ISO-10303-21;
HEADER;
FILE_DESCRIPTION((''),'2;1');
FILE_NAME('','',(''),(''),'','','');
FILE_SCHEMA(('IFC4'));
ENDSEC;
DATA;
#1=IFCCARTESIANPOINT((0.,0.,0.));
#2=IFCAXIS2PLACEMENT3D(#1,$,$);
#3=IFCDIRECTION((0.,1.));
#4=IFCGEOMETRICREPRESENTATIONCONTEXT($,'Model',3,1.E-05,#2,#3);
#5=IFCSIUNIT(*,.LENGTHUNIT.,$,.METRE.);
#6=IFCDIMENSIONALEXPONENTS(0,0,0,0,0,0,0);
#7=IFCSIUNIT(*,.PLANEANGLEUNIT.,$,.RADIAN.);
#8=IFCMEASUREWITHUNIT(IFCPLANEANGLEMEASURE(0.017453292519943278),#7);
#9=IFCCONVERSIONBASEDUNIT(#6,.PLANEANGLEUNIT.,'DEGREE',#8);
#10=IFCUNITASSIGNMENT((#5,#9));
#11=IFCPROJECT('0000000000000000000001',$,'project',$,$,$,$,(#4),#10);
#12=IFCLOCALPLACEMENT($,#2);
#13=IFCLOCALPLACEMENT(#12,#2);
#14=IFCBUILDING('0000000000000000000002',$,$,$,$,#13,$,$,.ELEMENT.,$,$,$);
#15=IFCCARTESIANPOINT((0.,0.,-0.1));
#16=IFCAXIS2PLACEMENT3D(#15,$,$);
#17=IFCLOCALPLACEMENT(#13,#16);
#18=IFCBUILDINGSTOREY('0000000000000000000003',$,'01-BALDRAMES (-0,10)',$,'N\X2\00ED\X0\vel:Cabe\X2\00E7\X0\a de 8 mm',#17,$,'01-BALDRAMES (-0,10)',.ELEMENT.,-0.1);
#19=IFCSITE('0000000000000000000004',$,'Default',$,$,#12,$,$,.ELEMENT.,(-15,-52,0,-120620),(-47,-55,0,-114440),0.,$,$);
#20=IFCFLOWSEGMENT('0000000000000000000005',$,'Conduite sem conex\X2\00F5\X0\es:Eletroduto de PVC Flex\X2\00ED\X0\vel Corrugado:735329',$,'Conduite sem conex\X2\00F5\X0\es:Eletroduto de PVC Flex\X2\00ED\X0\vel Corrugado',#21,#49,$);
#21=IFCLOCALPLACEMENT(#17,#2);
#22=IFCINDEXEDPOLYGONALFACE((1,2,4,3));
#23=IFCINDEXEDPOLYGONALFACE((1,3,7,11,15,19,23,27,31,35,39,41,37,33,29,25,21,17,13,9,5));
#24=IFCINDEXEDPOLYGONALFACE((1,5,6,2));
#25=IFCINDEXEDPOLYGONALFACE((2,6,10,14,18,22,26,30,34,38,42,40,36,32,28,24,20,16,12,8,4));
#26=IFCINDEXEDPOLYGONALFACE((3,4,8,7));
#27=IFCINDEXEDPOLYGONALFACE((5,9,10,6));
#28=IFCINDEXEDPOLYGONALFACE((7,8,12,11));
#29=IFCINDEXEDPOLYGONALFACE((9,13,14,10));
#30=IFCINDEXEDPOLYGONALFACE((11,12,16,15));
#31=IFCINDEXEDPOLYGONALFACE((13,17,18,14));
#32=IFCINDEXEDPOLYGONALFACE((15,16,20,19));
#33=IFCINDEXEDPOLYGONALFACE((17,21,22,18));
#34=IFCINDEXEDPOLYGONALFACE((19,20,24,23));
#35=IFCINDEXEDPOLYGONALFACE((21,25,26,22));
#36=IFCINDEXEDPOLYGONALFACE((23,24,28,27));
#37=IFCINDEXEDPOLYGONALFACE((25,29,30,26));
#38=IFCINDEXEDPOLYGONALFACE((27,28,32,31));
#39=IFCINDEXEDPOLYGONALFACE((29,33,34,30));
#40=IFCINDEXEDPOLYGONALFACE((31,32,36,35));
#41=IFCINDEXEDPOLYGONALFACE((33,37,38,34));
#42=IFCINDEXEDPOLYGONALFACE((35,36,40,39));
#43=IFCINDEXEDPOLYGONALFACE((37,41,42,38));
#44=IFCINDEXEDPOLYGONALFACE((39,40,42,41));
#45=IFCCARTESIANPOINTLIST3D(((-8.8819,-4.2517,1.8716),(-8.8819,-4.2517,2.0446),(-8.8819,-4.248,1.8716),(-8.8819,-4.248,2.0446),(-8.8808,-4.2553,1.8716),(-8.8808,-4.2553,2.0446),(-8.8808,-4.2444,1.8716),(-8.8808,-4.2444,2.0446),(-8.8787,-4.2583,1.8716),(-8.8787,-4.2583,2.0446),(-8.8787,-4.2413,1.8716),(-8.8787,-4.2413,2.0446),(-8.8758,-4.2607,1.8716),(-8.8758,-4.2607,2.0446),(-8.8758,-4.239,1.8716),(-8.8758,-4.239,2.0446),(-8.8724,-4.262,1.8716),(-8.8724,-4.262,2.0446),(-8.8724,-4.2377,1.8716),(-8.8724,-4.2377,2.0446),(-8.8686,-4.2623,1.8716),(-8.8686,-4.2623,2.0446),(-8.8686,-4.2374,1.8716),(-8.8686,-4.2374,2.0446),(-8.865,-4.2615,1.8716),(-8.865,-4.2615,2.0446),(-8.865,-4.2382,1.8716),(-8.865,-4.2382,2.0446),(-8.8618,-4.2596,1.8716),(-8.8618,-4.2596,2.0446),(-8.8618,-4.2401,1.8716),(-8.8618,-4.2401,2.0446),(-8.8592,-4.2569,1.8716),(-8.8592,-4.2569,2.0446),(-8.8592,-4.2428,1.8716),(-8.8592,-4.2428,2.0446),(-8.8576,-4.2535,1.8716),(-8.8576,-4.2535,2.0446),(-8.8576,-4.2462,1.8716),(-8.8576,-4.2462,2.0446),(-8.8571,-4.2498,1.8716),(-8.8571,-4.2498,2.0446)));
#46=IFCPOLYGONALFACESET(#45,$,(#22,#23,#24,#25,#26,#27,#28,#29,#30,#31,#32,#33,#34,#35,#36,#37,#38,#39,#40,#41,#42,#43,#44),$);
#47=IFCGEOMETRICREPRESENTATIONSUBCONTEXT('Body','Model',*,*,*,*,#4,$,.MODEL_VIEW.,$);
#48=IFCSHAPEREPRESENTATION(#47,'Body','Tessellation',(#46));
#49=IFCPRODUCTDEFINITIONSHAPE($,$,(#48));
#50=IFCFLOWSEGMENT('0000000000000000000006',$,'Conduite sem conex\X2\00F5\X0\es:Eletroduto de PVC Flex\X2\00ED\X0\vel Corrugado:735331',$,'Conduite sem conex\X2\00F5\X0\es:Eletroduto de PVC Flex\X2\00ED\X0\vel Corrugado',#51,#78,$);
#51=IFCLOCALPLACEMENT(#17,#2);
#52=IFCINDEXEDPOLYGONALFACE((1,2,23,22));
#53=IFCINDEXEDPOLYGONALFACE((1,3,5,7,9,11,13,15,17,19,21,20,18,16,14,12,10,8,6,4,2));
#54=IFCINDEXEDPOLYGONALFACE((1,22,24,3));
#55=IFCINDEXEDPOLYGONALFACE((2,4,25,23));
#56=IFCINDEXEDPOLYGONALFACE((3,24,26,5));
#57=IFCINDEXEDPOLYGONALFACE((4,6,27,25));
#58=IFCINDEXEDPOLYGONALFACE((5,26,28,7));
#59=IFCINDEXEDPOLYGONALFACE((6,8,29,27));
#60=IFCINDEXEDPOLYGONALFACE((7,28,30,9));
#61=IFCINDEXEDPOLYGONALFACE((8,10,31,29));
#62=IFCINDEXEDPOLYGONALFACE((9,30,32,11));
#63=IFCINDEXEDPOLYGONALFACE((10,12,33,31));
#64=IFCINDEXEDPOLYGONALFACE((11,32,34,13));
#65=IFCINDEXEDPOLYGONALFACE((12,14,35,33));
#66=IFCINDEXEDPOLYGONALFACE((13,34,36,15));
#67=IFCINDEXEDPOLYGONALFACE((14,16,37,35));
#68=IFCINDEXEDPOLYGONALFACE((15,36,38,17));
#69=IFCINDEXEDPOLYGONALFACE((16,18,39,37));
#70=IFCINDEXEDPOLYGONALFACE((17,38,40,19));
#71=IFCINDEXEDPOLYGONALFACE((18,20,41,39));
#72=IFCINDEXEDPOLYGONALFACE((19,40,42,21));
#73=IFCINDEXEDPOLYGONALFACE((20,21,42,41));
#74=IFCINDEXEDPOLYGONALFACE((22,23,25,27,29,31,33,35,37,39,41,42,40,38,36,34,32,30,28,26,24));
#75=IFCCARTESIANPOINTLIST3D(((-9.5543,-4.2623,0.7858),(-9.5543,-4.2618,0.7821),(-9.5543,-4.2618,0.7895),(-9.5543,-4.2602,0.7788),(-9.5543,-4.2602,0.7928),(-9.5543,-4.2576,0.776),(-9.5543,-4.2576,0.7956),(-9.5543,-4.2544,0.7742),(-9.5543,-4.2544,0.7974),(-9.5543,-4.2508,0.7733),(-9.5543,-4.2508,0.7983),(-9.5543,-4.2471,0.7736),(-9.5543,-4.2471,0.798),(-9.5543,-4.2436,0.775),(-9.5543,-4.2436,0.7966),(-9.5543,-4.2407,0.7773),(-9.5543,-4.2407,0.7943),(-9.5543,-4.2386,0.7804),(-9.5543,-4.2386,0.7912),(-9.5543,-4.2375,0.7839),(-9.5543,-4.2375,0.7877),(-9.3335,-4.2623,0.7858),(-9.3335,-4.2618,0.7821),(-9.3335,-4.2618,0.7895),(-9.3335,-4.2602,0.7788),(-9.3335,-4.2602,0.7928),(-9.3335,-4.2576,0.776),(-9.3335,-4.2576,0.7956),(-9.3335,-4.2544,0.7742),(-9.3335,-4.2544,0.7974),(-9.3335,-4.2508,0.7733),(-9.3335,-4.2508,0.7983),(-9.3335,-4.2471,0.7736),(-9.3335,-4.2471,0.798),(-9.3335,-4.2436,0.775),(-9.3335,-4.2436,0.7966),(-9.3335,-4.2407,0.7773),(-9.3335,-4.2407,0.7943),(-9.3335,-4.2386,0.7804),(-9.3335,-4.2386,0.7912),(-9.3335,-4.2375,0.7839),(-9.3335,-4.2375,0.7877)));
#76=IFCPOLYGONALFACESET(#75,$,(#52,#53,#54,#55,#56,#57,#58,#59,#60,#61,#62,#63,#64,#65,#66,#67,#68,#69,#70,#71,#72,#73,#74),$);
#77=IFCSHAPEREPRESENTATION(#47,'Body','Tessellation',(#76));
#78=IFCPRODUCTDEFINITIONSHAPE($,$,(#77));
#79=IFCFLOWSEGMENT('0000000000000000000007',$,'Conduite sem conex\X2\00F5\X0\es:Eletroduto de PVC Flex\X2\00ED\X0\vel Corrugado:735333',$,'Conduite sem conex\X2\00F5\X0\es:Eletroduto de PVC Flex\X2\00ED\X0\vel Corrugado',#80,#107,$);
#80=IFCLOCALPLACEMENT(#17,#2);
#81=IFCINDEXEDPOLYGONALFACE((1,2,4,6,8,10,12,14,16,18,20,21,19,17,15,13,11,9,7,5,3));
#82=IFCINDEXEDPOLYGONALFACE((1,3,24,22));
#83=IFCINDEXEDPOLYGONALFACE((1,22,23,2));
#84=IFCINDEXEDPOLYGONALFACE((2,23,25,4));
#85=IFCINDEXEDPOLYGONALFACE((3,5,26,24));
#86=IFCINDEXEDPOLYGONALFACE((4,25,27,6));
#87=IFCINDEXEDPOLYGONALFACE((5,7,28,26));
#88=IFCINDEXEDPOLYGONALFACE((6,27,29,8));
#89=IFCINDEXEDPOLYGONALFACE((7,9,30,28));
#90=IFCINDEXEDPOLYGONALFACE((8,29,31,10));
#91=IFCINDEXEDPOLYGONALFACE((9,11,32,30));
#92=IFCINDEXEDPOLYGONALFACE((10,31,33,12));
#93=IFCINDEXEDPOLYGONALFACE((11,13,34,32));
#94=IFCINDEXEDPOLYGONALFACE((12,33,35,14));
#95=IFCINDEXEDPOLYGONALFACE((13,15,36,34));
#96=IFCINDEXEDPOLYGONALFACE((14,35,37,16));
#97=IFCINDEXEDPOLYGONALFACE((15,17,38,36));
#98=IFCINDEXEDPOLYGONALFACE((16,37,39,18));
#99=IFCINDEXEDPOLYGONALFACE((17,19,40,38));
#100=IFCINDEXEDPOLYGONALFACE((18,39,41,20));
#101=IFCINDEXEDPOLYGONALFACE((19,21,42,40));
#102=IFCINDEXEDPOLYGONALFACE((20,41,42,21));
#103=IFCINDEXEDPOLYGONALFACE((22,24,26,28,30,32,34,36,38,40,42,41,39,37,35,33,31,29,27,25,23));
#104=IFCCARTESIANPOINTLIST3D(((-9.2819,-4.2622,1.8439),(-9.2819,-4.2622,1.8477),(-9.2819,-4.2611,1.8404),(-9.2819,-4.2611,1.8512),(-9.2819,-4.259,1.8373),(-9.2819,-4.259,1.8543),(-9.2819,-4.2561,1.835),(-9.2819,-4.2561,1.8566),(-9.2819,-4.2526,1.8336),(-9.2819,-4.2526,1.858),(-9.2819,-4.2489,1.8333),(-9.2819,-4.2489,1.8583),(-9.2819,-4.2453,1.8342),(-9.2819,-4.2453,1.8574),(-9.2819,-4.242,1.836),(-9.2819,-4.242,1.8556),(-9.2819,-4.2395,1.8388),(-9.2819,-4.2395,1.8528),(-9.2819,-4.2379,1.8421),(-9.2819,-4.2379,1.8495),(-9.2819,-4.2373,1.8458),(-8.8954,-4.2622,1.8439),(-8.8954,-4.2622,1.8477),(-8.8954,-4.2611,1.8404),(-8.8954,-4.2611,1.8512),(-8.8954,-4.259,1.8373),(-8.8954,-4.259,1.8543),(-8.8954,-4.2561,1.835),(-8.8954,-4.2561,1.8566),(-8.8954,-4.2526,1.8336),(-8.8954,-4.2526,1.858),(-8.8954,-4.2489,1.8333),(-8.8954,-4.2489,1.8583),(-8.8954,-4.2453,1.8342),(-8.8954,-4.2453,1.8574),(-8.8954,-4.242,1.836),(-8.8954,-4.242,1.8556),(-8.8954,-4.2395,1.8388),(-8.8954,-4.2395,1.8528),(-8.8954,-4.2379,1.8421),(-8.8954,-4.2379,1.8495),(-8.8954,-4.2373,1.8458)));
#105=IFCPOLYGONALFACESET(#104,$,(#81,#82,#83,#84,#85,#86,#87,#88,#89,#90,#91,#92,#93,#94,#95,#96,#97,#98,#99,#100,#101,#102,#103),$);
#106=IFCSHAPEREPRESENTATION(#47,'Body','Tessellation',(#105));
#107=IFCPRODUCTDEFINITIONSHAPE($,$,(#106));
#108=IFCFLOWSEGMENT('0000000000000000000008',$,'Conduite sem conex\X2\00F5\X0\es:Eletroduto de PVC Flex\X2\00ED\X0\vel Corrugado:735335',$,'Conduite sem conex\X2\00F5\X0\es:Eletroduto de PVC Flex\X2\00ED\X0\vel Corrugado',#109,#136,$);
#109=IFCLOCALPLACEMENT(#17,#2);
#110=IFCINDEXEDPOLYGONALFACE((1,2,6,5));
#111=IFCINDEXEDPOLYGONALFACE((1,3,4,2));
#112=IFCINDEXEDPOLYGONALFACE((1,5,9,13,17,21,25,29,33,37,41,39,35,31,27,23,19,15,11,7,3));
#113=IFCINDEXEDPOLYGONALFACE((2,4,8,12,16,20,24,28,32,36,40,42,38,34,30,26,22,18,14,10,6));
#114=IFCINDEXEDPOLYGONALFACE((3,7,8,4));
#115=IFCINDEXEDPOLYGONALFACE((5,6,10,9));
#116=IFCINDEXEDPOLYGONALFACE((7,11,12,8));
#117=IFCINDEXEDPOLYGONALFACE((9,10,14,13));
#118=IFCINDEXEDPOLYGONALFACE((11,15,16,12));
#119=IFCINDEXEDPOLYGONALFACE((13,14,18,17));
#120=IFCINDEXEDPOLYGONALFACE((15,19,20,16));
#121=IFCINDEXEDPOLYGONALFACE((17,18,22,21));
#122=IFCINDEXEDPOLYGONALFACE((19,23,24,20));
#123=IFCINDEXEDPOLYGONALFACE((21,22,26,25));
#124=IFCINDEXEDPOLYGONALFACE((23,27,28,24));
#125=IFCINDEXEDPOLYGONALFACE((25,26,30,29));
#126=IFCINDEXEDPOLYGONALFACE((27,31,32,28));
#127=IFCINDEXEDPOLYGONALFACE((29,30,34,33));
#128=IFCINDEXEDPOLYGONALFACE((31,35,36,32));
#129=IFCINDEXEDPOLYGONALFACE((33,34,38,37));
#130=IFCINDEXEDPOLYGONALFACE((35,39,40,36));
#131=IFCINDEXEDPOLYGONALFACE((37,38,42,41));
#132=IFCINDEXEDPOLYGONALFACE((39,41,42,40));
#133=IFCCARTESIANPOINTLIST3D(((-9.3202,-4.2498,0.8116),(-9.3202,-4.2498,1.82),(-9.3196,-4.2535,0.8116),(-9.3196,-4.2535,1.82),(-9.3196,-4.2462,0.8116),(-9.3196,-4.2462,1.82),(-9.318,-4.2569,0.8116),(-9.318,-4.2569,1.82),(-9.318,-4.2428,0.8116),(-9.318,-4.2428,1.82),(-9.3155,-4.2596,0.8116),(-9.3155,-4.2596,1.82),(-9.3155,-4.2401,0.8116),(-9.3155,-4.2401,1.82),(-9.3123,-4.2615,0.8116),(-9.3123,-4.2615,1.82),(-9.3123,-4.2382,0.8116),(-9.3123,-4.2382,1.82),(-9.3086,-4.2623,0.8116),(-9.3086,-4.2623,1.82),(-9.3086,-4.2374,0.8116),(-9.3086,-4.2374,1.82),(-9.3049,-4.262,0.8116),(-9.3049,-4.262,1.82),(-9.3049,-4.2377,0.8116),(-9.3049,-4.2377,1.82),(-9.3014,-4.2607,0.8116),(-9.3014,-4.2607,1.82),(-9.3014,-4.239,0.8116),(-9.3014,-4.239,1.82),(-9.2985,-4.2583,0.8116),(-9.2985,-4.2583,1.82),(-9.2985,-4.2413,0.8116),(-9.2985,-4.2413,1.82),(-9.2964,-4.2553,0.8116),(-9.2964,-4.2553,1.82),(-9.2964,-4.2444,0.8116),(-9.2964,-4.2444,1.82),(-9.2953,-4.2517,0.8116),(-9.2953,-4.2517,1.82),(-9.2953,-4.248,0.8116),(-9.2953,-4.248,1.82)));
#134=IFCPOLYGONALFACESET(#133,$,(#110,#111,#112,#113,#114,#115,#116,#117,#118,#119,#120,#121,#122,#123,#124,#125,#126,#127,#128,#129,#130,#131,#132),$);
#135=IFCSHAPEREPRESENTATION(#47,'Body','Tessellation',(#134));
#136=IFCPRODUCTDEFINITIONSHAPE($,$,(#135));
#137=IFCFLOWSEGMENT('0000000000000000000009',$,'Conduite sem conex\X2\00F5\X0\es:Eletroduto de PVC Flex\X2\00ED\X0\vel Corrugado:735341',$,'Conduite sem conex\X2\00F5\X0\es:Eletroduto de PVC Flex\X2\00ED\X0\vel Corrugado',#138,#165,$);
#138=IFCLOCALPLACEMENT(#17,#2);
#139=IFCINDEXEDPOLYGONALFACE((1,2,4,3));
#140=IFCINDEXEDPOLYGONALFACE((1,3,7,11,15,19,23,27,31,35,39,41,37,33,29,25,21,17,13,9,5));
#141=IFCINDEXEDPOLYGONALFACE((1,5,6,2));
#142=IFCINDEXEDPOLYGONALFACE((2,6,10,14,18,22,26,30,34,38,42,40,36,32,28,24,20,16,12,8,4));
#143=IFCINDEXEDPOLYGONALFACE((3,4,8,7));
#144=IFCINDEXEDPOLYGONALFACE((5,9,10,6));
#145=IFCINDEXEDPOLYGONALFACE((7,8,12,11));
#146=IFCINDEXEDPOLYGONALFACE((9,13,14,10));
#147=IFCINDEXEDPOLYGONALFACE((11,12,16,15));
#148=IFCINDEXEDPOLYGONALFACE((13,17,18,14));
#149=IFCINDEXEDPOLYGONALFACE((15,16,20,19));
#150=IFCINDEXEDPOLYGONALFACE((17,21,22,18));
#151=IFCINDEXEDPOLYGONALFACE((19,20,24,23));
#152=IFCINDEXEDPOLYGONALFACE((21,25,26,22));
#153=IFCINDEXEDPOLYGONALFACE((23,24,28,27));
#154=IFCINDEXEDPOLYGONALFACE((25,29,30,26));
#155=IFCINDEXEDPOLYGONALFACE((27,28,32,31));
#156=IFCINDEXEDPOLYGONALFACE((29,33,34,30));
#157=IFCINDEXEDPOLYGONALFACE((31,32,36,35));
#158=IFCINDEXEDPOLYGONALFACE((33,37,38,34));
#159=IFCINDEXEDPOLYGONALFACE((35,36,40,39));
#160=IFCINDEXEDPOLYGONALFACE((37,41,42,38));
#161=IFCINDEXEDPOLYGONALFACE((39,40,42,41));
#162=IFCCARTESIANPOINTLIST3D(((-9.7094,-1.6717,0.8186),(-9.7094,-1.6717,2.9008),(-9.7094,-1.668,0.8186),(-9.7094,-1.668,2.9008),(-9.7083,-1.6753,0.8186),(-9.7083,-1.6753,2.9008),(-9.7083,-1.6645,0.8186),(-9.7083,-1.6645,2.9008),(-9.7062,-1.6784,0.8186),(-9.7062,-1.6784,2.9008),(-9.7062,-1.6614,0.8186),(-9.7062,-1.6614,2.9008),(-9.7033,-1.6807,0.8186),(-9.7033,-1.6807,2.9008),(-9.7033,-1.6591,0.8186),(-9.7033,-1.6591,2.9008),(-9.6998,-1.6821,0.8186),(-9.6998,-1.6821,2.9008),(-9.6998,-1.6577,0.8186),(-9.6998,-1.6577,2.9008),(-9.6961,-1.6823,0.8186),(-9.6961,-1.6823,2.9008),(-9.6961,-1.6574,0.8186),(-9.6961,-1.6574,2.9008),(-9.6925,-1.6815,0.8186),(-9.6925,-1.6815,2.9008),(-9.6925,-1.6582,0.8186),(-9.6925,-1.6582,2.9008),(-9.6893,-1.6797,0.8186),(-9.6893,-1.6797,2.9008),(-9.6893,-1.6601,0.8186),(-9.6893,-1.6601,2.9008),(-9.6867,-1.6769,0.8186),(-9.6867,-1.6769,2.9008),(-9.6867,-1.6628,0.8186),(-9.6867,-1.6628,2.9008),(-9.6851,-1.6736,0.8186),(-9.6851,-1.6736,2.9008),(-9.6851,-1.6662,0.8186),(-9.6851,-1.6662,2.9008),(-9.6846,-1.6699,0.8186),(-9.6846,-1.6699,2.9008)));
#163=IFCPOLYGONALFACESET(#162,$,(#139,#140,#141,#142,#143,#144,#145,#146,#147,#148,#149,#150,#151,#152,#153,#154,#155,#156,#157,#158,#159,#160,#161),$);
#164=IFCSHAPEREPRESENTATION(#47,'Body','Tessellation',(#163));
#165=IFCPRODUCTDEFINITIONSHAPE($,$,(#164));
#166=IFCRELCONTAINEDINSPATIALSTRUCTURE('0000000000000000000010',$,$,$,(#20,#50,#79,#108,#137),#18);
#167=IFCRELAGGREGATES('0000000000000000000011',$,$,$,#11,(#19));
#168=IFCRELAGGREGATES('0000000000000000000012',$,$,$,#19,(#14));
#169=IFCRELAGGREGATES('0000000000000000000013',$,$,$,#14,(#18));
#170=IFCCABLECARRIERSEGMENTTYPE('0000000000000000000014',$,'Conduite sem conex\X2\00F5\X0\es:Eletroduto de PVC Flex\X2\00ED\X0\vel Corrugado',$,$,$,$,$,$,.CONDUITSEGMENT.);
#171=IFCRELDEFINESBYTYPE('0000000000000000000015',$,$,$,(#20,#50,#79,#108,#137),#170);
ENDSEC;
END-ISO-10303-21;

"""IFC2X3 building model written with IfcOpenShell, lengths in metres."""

from ifc_helpers import new_model, entity, si_unit, converted_unit, direction, frame, frame_2d, origin, origin_2d_with_axis, place, context, subcontext, project, spatial, circle, extrude, type_object, element, save


model = new_model("IFC2X3")

# Units and contexts
model_context = context("Model", 3, precision=1e-05, world=origin(), true_north=direction((0.0, 1.0)))
body_context = subcontext(model_context, "Body", "Model", "MODEL_VIEW")
ifc_project = project(units=[si_unit("LENGTHUNIT", "METRE"), converted_unit("PLANEANGLEUNIT", "DEGREE", entity("IfcPlaneAngleMeasure", 0.017453292519943278), si_unit("PLANEANGLEUNIT", "RADIAN"), dimensions=[0, 0, 0, 0, 0, 0, 0])], contexts=[model_context])

# Site, building, storey
site_placement = place(None, origin())
site = spatial("IfcSite", under=ifc_project, at=site_placement, Name="Default", CompositionType="ELEMENT", RefLatitude=(-15, -52, 0, -120620), RefLongitude=(-47, -55, 0, -114440), RefElevation=0.0)
building_placement = place(site_placement, origin())
building = spatial("IfcBuilding", under=site, at=building_placement, CompositionType="ELEMENT")
storey_placement = place(building_placement, frame((0.0, 0.0, -0.1)))
storey = spatial("IfcBuildingStorey", under=building, at=storey_placement, Name="01-BALDRAMES (-0,10)", ObjectType="Nível:Cabeça de 8 mm", LongName="01-BALDRAMES (-0,10)", CompositionType="ELEMENT", Elevation=-0.1)

# Flow segments
cable_carrier_segment_type = type_object("IfcCableCarrierSegmentType", Name="Conduite sem conexões:Eletroduto de PVC Flexível Corrugado", PredefinedType="CONDUITSEGMENT")
flow_segment_1_placement = place(storey_placement, origin())
element("IfcFlowSegment", 1, at=flow_segment_1_placement, inside=storey, type_object=cable_carrier_segment_type, Name="Conduite sem conexões:Eletroduto de PVC Flexível Corrugado:735329", ObjectType="Conduite sem conexões:Eletroduto de PVC Flexível Corrugado", context=body_context, shape_type="SweptSolid", body=[
    extrude(circle(Radius=0.0125, at=origin_2d_with_axis()), frame((-8.8696, -4.2498, 1.8716)), (0.0, 0.0, 1.0), 0.173),
])
flow_segment_2_placement = place(storey_placement, origin())
element("IfcFlowSegment", 2, at=flow_segment_2_placement, inside=storey, type_object=cable_carrier_segment_type, Name="Conduite sem conexões:Eletroduto de PVC Flexível Corrugado:735331", ObjectType="Conduite sem conexões:Eletroduto de PVC Flexível Corrugado", context=body_context, shape_type="SweptSolid", body=[
    extrude(circle(Radius=0.0125, at=frame_2d((0.0, 0.0), x_axis=(1.0, 0.0))), frame((-9.5543, -4.2498, 0.7858), z_axis=(1.0, 0.0, 0.0), x_axis=(0.0, -1.0, 0.0)), (0.0, 0.0, 1.0), 0.2208),
])
flow_segment_3_placement = place(storey_placement, origin())
element("IfcFlowSegment", 3, at=flow_segment_3_placement, inside=storey, type_object=cable_carrier_segment_type, Name="Conduite sem conexões:Eletroduto de PVC Flexível Corrugado:735333", ObjectType="Conduite sem conexões:Eletroduto de PVC Flexível Corrugado", context=body_context, shape_type="SweptSolid", body=[
    extrude(circle(Radius=0.0125, at=origin_2d_with_axis()), frame((-9.2819, -4.2498, 1.8458), z_axis=(1.0, 0.0, 0.0), x_axis=(0.0, 1.0, 0.0)), (0.0, 0.0, 1.0), 0.3865),
])
flow_segment_4_placement = place(storey_placement, origin())
element("IfcFlowSegment", 4, at=flow_segment_4_placement, inside=storey, type_object=cable_carrier_segment_type, Name="Conduite sem conexões:Eletroduto de PVC Flexível Corrugado:735335", ObjectType="Conduite sem conexões:Eletroduto de PVC Flexível Corrugado", context=body_context, shape_type="SweptSolid", body=[
    extrude(circle(Radius=0.0125, at=frame_2d((0.0, 0.0), x_axis=(1.0, 0.0))), frame((-9.3077, -4.2498, 0.8116), z_axis=(0.0, 0.0, 1.0), x_axis=(-1.0, 0.0, 0.0)), (0.0, 0.0, 1.0), 1.0084),
])
flow_segment_5_placement = place(storey_placement, origin())
element("IfcFlowSegment", 5, at=flow_segment_5_placement, inside=storey, type_object=cable_carrier_segment_type, Name="Conduite sem conexões:Eletroduto de PVC Flexível Corrugado:735341", ObjectType="Conduite sem conexões:Eletroduto de PVC Flexível Corrugado", context=body_context, shape_type="SweptSolid", body=[
    extrude(circle(Radius=0.0125, at=frame_2d((0.0, 0.0), x_axis=(1.0, 0.0))), frame((-9.6971, -1.6699, 0.8186)), (0.0, 0.0, 1.0), 2.0822),
])

save(model, "model.ifc")
